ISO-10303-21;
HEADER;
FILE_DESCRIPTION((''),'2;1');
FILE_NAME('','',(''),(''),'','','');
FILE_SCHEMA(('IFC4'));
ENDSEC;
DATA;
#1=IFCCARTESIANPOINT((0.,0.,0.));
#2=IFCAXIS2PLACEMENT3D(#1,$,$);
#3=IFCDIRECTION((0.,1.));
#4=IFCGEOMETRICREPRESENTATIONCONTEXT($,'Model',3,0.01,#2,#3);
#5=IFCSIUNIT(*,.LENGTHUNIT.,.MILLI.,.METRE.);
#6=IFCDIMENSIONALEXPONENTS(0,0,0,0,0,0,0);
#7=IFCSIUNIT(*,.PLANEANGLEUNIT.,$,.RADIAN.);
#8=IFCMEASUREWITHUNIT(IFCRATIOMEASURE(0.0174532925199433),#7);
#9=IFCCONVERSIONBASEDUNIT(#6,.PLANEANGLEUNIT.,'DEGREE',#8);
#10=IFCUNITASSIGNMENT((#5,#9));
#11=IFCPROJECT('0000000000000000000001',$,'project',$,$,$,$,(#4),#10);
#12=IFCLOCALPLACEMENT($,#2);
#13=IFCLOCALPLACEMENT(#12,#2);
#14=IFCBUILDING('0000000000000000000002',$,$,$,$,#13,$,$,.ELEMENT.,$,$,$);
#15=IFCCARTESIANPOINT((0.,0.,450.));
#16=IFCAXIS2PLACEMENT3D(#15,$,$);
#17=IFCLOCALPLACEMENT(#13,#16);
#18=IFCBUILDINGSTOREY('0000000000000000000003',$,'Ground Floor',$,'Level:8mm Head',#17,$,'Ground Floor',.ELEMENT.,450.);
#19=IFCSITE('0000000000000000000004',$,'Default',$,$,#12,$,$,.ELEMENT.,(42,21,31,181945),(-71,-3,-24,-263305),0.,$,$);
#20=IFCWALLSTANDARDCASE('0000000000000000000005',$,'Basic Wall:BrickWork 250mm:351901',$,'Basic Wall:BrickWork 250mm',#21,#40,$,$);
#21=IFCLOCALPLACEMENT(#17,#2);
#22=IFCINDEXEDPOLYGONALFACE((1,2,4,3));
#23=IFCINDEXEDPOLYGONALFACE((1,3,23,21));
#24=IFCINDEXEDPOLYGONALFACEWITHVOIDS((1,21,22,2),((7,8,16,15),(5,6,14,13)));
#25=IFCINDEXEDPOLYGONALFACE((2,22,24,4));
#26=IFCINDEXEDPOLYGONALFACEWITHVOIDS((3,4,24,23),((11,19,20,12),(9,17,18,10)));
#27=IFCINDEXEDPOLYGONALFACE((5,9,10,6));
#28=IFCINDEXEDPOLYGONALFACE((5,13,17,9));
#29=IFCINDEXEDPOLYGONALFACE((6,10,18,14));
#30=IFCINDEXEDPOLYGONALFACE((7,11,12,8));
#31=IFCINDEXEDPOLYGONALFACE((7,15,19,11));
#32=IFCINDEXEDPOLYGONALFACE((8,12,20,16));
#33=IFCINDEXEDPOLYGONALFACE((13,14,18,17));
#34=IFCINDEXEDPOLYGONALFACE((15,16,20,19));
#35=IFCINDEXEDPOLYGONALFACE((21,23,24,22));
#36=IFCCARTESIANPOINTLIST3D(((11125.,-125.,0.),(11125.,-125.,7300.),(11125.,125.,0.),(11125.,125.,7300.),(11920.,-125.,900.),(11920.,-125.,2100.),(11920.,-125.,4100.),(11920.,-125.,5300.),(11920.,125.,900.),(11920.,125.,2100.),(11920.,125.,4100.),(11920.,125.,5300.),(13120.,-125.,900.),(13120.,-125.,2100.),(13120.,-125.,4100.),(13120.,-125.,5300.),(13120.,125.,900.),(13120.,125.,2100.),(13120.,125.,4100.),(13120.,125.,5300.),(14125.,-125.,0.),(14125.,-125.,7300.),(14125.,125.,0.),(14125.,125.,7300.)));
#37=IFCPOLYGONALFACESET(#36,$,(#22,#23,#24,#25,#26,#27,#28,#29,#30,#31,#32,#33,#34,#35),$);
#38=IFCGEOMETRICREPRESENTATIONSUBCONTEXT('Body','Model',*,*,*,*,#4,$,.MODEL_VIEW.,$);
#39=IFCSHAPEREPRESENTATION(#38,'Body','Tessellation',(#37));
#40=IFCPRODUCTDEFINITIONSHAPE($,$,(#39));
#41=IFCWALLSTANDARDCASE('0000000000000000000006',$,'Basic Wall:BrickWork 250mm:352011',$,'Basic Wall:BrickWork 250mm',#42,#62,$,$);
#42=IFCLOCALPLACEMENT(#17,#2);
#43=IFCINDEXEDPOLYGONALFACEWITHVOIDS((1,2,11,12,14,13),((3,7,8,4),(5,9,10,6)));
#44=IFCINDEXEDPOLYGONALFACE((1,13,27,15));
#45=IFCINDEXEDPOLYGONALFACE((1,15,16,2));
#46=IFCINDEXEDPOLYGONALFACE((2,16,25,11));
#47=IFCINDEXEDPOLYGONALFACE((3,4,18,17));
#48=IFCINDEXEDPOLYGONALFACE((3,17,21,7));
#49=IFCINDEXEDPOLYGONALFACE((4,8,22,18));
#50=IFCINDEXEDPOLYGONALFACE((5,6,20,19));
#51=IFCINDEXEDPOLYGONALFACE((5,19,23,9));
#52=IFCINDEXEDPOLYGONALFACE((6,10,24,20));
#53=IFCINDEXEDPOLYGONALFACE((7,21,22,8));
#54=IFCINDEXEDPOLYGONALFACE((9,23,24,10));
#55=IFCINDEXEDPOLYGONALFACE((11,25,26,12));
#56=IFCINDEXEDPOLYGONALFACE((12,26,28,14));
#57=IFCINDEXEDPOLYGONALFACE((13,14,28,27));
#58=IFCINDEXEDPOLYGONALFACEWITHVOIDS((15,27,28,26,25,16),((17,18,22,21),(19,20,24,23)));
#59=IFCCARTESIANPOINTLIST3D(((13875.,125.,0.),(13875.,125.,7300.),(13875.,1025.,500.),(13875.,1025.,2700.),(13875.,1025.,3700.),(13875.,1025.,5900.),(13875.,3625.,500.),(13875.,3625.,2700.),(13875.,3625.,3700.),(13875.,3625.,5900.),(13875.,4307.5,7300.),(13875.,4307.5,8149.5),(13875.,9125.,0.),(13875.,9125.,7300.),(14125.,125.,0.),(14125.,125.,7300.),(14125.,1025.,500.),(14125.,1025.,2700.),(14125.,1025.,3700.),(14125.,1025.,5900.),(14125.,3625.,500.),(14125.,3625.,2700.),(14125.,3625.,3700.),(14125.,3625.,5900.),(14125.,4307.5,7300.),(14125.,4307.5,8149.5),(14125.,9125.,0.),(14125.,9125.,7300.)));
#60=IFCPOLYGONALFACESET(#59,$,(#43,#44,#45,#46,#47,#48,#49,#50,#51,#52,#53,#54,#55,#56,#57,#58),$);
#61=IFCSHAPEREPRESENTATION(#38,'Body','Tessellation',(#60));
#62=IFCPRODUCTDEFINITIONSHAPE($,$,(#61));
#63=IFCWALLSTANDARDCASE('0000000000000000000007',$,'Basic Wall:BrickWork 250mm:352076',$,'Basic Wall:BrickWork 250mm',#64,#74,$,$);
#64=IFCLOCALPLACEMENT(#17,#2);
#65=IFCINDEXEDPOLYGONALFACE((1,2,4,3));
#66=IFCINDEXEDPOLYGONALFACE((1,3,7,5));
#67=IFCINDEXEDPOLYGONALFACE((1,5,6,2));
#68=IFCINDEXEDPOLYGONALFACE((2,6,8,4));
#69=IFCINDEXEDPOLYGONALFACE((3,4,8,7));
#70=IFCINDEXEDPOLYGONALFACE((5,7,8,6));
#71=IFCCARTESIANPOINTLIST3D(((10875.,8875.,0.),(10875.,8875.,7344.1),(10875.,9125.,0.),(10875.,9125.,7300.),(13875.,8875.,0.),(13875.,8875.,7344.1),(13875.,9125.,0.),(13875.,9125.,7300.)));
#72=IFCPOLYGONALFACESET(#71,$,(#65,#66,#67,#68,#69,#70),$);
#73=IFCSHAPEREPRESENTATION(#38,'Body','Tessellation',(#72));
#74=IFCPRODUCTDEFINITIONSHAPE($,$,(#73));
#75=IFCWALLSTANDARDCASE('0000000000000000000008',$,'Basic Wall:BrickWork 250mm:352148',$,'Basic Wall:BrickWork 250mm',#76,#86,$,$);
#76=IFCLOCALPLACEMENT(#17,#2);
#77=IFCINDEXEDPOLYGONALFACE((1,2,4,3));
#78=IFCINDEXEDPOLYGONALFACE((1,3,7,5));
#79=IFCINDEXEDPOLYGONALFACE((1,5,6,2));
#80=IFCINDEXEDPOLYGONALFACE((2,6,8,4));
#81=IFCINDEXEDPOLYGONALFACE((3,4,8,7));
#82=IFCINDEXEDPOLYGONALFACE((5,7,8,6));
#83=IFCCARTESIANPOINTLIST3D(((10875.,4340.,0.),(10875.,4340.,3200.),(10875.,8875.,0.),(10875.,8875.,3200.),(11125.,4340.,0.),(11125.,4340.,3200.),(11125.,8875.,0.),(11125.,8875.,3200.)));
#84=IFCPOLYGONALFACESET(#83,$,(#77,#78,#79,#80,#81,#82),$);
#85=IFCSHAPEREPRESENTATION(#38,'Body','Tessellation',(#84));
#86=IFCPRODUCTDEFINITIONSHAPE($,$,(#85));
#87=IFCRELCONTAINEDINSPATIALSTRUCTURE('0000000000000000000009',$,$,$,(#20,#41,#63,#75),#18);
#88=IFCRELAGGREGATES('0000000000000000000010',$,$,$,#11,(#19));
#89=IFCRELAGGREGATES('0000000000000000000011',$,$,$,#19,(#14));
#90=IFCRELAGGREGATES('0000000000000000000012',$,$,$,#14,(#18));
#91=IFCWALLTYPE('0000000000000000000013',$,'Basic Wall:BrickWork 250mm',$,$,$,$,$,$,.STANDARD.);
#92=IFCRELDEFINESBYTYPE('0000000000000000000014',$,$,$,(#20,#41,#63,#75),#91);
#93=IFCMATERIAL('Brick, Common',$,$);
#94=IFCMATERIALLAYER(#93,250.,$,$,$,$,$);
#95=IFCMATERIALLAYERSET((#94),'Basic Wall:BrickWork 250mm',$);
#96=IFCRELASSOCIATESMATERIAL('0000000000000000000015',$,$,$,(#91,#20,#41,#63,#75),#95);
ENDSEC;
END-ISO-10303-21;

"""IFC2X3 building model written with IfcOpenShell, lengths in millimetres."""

from ifc_helpers import new_model, entity, si_unit, converted_unit, direction, frame, frame_2d, origin, place, context, subcontext, project, spatial, polyline, rectangle, extrude, clip, bounded_halfspace, material, layer, layer_set, layer_usage, type_object, element, save


model = new_model("IFC2X3")

# Units and contexts
model_context = context("Model", 3, precision=0.01, world=origin(), true_north=direction((0.0, 1.0)))
body_context = subcontext(model_context, "Body", "Model", "MODEL_VIEW")
ifc_project = project(units=[si_unit("LENGTHUNIT", "METRE", prefix="MILLI"), converted_unit("PLANEANGLEUNIT", "DEGREE", entity("IfcRatioMeasure", 0.0174532925199433), si_unit("PLANEANGLEUNIT", "RADIAN"), dimensions=[0, 0, 0, 0, 0, 0, 0])], contexts=[model_context])

# Site, building, storey
site_placement = place(None, origin())
site = spatial("IfcSite", under=ifc_project, at=site_placement, Name="Default", CompositionType="ELEMENT", RefLatitude=(42, 21, 31, 181945), RefLongitude=(-71, -3, -24, -263305), RefElevation=0.0)
building_placement = place(site_placement, origin())
building = spatial("IfcBuilding", under=site, at=building_placement, CompositionType="ELEMENT")
storey_placement = place(building_placement, frame((0.0, 0.0, 450.0)))
storey = spatial("IfcBuildingStorey", under=building, at=storey_placement, Name="Ground Floor", ObjectType="Level:8mm Head", LongName="Ground Floor", CompositionType="ELEMENT", Elevation=450.0)

# Shared definitions
ifc_material_1 = material(Name="Brick, Common")
ifc_layer_1 = layer(ifc_material_1, 250.0)
ifc_layer_set_1 = layer_set([ifc_layer_1], Name="Basic Wall:BrickWork 250mm")
wall_type_1 = type_object("IfcWallType", Name="Basic Wall:BrickWork 250mm", PredefinedType="STANDARD", material=ifc_layer_set_1)

# Walls, openings
ifc_layer_usage_1 = layer_usage(ifc_layer_set_1, "AXIS2", "POSITIVE", -125.0)
wall_1_placement = place(storey_placement, frame((11125.0, 0.0, 0.0)))
wall_1 = element("IfcWallStandardCase", 1, at=wall_1_placement, inside=storey, type_object=wall_type_1, material=ifc_layer_usage_1, Name="Basic Wall:BrickWork 250mm:351901", ObjectType="Basic Wall:BrickWork 250mm", context=body_context, shape_type="SweptSolid", body=[
    extrude(rectangle(XDim=3000.0, YDim=250.0, at=frame_2d((1500.0, 0.0), x_axis=(-1.0, 0.0))), origin(), (0.0, 0.0, 1.0), 7300.0),
])
opening_1_placement = place(wall_1_placement, frame((1995.0, 125.0, 900.0)))
element("IfcOpeningElement", 2, at=opening_1_placement, cuts=wall_1, ObjectType="Opening", context=body_context, shape_type="SweptSolid", body=[
    extrude(rectangle(XDim=1200.0, YDim=1200.0, at=frame_2d((600.0, 600.0), x_axis=(-1.0, 0.0))), frame((0.0, 0.0, 0.0), z_axis=(0.0, -1.0, 0.0), x_axis=(0.0, 0.0, 1.0)), (0.0, 0.0, 1.0), 250.0),
])
opening_2_placement = place(wall_1_placement, frame((1995.0, 125.0, 4100.0)))
element("IfcOpeningElement", 3, at=opening_2_placement, cuts=wall_1, ObjectType="Opening", context=body_context, shape_type="SweptSolid", body=[
    extrude(rectangle(XDim=1200.0, YDim=1200.0, at=frame_2d((600.0, 600.0), x_axis=(-1.0, 0.0))), frame((0.0, 0.0, 0.0), z_axis=(0.0, -1.0, 0.0), x_axis=(0.0, 0.0, 1.0)), (0.0, 0.0, 1.0), 250.0),
])
ifc_layer_usage_2 = layer_usage(ifc_layer_set_1, "AXIS2", "POSITIVE", -125.0)
wall_2_placement = place(storey_placement, frame((14000.0, 125.0, 0.0), z_axis=(0.0, 0.0, 1.0), x_axis=(0.0, 1.0, 0.0)))
wall_2 = element("IfcWallStandardCase", 4, at=wall_2_placement, inside=storey, type_object=wall_type_1, material=ifc_layer_usage_2, Name="Basic Wall:BrickWork 250mm:352011", ObjectType="Basic Wall:BrickWork 250mm", context=body_context, shape_type="Clipping", body=[
    clip(clip(extrude(rectangle(XDim=9000.0, YDim=250.0, at=frame_2d((4500.0, 0.0), x_axis=(-1.0, 0.0))), origin(), (0.0, 0.0, 1.0), 8149.5), bounded_halfspace(frame((4182.5, -125.0, 8149.5), z_axis=(0.173648, 0.0, 0.984808), x_axis=(0.0, 1.0, 0.0)), False, frame((4182.5, -125.0, 8149.5)), polyline([(0.0, 0.0), (4817.5, 0.0), (4817.5, 250.0), (4567.5, 250.0), (282.5, 250.0), (32.5, 250.0), (0.0, 250.0), (0.0, 0.0)]))), bounded_halfspace(frame((0.0, 125.0, 7300.0), z_axis=(0.0, 0.0, 1.0), x_axis=(0.0, 1.0, 0.0)), False, frame((0.0, 125.0, 7300.0)), polyline([(0.0, 0.0), (0.0, -250.0), (4182.5, -250.0), (4182.5, 0.0), (0.0, 0.0)]))),
])
opening_3_placement = place(wall_2_placement, origin())
element("IfcOpeningElement", 5, at=opening_3_placement, cuts=wall_2, ObjectType="Opening", context=body_context, shape_type="SweptSolid", body=[
    extrude(rectangle(XDim=2200.0, YDim=2600.0, at=frame_2d((0.0, 0.0), x_axis=(1.0, 0.0))), frame((2200.0, -277.4, 1600.0), z_axis=(0.0, 1.0, 0.0), x_axis=(0.0, 0.0, 1.0)), (0.0, 0.0, 1.0), 554.8),
])
opening_4_placement = place(wall_2_placement, origin())
element("IfcOpeningElement", 6, at=opening_4_placement, cuts=wall_2, ObjectType="Opening", context=body_context, shape_type="SweptSolid", body=[
    extrude(rectangle(XDim=2200.0, YDim=2600.0, at=frame_2d((0.0, 0.0), x_axis=(1.0, 0.0))), frame((2200.0, -277.4, 4800.0), z_axis=(0.0, 1.0, 0.0), x_axis=(0.0, 0.0, 1.0)), (0.0, 0.0, 1.0), 554.8),
])

# Walls
ifc_layer_usage_3 = layer_usage(ifc_layer_set_1, "AXIS2", "POSITIVE", -125.0)
wall_3_placement = place(storey_placement, frame((13875.0, 9000.0, 0.0), z_axis=(0.0, 0.0, 1.0), x_axis=(-1.0, 0.0, 0.0)))
element("IfcWallStandardCase", 7, at=wall_3_placement, inside=storey, type_object=wall_type_1, material=ifc_layer_usage_3, Name="Basic Wall:BrickWork 250mm:352076", ObjectType="Basic Wall:BrickWork 250mm", context=body_context, shape_type="Clipping", body=[
    clip(extrude(rectangle(XDim=3000.0, YDim=250.0, at=frame_2d((1500.0, 0.0), x_axis=(-1.0, 0.0))), origin(), (0.0, 0.0, 1.0), 7344.1), bounded_halfspace(frame((0.0, -125.0, 7300.0), z_axis=(0.0, -0.173648, 0.984808), x_axis=(1.0, 0.0, 0.0)), False, frame((0.0, -125.0, 7300.0)), polyline([(0.0, 0.0), (3000.0, 0.0), (3000.0, 250.0), (2750.0, 250.0), (0.0, 250.0), (0.0, 0.0)]))),
])
ifc_layer_usage_4 = layer_usage(ifc_layer_set_1, "AXIS2", "POSITIVE", -125.0)
wall_4_placement = place(storey_placement, frame((11000.0, 8875.0, 0.0), z_axis=(0.0, 0.0, 1.0), x_axis=(0.0, -1.0, 0.0)))
element("IfcWallStandardCase", 8, at=wall_4_placement, inside=storey, type_object=wall_type_1, material=ifc_layer_usage_4, Name="Basic Wall:BrickWork 250mm:352148", ObjectType="Basic Wall:BrickWork 250mm", context=body_context, shape_type="SweptSolid", body=[
    extrude(rectangle(XDim=4535.0, YDim=250.0, at=frame_2d((2267.5, 0.0), x_axis=(-1.0, 0.0))), origin(), (0.0, 0.0, 1.0), 3200.0),
])

save(model, "model.ifc")
